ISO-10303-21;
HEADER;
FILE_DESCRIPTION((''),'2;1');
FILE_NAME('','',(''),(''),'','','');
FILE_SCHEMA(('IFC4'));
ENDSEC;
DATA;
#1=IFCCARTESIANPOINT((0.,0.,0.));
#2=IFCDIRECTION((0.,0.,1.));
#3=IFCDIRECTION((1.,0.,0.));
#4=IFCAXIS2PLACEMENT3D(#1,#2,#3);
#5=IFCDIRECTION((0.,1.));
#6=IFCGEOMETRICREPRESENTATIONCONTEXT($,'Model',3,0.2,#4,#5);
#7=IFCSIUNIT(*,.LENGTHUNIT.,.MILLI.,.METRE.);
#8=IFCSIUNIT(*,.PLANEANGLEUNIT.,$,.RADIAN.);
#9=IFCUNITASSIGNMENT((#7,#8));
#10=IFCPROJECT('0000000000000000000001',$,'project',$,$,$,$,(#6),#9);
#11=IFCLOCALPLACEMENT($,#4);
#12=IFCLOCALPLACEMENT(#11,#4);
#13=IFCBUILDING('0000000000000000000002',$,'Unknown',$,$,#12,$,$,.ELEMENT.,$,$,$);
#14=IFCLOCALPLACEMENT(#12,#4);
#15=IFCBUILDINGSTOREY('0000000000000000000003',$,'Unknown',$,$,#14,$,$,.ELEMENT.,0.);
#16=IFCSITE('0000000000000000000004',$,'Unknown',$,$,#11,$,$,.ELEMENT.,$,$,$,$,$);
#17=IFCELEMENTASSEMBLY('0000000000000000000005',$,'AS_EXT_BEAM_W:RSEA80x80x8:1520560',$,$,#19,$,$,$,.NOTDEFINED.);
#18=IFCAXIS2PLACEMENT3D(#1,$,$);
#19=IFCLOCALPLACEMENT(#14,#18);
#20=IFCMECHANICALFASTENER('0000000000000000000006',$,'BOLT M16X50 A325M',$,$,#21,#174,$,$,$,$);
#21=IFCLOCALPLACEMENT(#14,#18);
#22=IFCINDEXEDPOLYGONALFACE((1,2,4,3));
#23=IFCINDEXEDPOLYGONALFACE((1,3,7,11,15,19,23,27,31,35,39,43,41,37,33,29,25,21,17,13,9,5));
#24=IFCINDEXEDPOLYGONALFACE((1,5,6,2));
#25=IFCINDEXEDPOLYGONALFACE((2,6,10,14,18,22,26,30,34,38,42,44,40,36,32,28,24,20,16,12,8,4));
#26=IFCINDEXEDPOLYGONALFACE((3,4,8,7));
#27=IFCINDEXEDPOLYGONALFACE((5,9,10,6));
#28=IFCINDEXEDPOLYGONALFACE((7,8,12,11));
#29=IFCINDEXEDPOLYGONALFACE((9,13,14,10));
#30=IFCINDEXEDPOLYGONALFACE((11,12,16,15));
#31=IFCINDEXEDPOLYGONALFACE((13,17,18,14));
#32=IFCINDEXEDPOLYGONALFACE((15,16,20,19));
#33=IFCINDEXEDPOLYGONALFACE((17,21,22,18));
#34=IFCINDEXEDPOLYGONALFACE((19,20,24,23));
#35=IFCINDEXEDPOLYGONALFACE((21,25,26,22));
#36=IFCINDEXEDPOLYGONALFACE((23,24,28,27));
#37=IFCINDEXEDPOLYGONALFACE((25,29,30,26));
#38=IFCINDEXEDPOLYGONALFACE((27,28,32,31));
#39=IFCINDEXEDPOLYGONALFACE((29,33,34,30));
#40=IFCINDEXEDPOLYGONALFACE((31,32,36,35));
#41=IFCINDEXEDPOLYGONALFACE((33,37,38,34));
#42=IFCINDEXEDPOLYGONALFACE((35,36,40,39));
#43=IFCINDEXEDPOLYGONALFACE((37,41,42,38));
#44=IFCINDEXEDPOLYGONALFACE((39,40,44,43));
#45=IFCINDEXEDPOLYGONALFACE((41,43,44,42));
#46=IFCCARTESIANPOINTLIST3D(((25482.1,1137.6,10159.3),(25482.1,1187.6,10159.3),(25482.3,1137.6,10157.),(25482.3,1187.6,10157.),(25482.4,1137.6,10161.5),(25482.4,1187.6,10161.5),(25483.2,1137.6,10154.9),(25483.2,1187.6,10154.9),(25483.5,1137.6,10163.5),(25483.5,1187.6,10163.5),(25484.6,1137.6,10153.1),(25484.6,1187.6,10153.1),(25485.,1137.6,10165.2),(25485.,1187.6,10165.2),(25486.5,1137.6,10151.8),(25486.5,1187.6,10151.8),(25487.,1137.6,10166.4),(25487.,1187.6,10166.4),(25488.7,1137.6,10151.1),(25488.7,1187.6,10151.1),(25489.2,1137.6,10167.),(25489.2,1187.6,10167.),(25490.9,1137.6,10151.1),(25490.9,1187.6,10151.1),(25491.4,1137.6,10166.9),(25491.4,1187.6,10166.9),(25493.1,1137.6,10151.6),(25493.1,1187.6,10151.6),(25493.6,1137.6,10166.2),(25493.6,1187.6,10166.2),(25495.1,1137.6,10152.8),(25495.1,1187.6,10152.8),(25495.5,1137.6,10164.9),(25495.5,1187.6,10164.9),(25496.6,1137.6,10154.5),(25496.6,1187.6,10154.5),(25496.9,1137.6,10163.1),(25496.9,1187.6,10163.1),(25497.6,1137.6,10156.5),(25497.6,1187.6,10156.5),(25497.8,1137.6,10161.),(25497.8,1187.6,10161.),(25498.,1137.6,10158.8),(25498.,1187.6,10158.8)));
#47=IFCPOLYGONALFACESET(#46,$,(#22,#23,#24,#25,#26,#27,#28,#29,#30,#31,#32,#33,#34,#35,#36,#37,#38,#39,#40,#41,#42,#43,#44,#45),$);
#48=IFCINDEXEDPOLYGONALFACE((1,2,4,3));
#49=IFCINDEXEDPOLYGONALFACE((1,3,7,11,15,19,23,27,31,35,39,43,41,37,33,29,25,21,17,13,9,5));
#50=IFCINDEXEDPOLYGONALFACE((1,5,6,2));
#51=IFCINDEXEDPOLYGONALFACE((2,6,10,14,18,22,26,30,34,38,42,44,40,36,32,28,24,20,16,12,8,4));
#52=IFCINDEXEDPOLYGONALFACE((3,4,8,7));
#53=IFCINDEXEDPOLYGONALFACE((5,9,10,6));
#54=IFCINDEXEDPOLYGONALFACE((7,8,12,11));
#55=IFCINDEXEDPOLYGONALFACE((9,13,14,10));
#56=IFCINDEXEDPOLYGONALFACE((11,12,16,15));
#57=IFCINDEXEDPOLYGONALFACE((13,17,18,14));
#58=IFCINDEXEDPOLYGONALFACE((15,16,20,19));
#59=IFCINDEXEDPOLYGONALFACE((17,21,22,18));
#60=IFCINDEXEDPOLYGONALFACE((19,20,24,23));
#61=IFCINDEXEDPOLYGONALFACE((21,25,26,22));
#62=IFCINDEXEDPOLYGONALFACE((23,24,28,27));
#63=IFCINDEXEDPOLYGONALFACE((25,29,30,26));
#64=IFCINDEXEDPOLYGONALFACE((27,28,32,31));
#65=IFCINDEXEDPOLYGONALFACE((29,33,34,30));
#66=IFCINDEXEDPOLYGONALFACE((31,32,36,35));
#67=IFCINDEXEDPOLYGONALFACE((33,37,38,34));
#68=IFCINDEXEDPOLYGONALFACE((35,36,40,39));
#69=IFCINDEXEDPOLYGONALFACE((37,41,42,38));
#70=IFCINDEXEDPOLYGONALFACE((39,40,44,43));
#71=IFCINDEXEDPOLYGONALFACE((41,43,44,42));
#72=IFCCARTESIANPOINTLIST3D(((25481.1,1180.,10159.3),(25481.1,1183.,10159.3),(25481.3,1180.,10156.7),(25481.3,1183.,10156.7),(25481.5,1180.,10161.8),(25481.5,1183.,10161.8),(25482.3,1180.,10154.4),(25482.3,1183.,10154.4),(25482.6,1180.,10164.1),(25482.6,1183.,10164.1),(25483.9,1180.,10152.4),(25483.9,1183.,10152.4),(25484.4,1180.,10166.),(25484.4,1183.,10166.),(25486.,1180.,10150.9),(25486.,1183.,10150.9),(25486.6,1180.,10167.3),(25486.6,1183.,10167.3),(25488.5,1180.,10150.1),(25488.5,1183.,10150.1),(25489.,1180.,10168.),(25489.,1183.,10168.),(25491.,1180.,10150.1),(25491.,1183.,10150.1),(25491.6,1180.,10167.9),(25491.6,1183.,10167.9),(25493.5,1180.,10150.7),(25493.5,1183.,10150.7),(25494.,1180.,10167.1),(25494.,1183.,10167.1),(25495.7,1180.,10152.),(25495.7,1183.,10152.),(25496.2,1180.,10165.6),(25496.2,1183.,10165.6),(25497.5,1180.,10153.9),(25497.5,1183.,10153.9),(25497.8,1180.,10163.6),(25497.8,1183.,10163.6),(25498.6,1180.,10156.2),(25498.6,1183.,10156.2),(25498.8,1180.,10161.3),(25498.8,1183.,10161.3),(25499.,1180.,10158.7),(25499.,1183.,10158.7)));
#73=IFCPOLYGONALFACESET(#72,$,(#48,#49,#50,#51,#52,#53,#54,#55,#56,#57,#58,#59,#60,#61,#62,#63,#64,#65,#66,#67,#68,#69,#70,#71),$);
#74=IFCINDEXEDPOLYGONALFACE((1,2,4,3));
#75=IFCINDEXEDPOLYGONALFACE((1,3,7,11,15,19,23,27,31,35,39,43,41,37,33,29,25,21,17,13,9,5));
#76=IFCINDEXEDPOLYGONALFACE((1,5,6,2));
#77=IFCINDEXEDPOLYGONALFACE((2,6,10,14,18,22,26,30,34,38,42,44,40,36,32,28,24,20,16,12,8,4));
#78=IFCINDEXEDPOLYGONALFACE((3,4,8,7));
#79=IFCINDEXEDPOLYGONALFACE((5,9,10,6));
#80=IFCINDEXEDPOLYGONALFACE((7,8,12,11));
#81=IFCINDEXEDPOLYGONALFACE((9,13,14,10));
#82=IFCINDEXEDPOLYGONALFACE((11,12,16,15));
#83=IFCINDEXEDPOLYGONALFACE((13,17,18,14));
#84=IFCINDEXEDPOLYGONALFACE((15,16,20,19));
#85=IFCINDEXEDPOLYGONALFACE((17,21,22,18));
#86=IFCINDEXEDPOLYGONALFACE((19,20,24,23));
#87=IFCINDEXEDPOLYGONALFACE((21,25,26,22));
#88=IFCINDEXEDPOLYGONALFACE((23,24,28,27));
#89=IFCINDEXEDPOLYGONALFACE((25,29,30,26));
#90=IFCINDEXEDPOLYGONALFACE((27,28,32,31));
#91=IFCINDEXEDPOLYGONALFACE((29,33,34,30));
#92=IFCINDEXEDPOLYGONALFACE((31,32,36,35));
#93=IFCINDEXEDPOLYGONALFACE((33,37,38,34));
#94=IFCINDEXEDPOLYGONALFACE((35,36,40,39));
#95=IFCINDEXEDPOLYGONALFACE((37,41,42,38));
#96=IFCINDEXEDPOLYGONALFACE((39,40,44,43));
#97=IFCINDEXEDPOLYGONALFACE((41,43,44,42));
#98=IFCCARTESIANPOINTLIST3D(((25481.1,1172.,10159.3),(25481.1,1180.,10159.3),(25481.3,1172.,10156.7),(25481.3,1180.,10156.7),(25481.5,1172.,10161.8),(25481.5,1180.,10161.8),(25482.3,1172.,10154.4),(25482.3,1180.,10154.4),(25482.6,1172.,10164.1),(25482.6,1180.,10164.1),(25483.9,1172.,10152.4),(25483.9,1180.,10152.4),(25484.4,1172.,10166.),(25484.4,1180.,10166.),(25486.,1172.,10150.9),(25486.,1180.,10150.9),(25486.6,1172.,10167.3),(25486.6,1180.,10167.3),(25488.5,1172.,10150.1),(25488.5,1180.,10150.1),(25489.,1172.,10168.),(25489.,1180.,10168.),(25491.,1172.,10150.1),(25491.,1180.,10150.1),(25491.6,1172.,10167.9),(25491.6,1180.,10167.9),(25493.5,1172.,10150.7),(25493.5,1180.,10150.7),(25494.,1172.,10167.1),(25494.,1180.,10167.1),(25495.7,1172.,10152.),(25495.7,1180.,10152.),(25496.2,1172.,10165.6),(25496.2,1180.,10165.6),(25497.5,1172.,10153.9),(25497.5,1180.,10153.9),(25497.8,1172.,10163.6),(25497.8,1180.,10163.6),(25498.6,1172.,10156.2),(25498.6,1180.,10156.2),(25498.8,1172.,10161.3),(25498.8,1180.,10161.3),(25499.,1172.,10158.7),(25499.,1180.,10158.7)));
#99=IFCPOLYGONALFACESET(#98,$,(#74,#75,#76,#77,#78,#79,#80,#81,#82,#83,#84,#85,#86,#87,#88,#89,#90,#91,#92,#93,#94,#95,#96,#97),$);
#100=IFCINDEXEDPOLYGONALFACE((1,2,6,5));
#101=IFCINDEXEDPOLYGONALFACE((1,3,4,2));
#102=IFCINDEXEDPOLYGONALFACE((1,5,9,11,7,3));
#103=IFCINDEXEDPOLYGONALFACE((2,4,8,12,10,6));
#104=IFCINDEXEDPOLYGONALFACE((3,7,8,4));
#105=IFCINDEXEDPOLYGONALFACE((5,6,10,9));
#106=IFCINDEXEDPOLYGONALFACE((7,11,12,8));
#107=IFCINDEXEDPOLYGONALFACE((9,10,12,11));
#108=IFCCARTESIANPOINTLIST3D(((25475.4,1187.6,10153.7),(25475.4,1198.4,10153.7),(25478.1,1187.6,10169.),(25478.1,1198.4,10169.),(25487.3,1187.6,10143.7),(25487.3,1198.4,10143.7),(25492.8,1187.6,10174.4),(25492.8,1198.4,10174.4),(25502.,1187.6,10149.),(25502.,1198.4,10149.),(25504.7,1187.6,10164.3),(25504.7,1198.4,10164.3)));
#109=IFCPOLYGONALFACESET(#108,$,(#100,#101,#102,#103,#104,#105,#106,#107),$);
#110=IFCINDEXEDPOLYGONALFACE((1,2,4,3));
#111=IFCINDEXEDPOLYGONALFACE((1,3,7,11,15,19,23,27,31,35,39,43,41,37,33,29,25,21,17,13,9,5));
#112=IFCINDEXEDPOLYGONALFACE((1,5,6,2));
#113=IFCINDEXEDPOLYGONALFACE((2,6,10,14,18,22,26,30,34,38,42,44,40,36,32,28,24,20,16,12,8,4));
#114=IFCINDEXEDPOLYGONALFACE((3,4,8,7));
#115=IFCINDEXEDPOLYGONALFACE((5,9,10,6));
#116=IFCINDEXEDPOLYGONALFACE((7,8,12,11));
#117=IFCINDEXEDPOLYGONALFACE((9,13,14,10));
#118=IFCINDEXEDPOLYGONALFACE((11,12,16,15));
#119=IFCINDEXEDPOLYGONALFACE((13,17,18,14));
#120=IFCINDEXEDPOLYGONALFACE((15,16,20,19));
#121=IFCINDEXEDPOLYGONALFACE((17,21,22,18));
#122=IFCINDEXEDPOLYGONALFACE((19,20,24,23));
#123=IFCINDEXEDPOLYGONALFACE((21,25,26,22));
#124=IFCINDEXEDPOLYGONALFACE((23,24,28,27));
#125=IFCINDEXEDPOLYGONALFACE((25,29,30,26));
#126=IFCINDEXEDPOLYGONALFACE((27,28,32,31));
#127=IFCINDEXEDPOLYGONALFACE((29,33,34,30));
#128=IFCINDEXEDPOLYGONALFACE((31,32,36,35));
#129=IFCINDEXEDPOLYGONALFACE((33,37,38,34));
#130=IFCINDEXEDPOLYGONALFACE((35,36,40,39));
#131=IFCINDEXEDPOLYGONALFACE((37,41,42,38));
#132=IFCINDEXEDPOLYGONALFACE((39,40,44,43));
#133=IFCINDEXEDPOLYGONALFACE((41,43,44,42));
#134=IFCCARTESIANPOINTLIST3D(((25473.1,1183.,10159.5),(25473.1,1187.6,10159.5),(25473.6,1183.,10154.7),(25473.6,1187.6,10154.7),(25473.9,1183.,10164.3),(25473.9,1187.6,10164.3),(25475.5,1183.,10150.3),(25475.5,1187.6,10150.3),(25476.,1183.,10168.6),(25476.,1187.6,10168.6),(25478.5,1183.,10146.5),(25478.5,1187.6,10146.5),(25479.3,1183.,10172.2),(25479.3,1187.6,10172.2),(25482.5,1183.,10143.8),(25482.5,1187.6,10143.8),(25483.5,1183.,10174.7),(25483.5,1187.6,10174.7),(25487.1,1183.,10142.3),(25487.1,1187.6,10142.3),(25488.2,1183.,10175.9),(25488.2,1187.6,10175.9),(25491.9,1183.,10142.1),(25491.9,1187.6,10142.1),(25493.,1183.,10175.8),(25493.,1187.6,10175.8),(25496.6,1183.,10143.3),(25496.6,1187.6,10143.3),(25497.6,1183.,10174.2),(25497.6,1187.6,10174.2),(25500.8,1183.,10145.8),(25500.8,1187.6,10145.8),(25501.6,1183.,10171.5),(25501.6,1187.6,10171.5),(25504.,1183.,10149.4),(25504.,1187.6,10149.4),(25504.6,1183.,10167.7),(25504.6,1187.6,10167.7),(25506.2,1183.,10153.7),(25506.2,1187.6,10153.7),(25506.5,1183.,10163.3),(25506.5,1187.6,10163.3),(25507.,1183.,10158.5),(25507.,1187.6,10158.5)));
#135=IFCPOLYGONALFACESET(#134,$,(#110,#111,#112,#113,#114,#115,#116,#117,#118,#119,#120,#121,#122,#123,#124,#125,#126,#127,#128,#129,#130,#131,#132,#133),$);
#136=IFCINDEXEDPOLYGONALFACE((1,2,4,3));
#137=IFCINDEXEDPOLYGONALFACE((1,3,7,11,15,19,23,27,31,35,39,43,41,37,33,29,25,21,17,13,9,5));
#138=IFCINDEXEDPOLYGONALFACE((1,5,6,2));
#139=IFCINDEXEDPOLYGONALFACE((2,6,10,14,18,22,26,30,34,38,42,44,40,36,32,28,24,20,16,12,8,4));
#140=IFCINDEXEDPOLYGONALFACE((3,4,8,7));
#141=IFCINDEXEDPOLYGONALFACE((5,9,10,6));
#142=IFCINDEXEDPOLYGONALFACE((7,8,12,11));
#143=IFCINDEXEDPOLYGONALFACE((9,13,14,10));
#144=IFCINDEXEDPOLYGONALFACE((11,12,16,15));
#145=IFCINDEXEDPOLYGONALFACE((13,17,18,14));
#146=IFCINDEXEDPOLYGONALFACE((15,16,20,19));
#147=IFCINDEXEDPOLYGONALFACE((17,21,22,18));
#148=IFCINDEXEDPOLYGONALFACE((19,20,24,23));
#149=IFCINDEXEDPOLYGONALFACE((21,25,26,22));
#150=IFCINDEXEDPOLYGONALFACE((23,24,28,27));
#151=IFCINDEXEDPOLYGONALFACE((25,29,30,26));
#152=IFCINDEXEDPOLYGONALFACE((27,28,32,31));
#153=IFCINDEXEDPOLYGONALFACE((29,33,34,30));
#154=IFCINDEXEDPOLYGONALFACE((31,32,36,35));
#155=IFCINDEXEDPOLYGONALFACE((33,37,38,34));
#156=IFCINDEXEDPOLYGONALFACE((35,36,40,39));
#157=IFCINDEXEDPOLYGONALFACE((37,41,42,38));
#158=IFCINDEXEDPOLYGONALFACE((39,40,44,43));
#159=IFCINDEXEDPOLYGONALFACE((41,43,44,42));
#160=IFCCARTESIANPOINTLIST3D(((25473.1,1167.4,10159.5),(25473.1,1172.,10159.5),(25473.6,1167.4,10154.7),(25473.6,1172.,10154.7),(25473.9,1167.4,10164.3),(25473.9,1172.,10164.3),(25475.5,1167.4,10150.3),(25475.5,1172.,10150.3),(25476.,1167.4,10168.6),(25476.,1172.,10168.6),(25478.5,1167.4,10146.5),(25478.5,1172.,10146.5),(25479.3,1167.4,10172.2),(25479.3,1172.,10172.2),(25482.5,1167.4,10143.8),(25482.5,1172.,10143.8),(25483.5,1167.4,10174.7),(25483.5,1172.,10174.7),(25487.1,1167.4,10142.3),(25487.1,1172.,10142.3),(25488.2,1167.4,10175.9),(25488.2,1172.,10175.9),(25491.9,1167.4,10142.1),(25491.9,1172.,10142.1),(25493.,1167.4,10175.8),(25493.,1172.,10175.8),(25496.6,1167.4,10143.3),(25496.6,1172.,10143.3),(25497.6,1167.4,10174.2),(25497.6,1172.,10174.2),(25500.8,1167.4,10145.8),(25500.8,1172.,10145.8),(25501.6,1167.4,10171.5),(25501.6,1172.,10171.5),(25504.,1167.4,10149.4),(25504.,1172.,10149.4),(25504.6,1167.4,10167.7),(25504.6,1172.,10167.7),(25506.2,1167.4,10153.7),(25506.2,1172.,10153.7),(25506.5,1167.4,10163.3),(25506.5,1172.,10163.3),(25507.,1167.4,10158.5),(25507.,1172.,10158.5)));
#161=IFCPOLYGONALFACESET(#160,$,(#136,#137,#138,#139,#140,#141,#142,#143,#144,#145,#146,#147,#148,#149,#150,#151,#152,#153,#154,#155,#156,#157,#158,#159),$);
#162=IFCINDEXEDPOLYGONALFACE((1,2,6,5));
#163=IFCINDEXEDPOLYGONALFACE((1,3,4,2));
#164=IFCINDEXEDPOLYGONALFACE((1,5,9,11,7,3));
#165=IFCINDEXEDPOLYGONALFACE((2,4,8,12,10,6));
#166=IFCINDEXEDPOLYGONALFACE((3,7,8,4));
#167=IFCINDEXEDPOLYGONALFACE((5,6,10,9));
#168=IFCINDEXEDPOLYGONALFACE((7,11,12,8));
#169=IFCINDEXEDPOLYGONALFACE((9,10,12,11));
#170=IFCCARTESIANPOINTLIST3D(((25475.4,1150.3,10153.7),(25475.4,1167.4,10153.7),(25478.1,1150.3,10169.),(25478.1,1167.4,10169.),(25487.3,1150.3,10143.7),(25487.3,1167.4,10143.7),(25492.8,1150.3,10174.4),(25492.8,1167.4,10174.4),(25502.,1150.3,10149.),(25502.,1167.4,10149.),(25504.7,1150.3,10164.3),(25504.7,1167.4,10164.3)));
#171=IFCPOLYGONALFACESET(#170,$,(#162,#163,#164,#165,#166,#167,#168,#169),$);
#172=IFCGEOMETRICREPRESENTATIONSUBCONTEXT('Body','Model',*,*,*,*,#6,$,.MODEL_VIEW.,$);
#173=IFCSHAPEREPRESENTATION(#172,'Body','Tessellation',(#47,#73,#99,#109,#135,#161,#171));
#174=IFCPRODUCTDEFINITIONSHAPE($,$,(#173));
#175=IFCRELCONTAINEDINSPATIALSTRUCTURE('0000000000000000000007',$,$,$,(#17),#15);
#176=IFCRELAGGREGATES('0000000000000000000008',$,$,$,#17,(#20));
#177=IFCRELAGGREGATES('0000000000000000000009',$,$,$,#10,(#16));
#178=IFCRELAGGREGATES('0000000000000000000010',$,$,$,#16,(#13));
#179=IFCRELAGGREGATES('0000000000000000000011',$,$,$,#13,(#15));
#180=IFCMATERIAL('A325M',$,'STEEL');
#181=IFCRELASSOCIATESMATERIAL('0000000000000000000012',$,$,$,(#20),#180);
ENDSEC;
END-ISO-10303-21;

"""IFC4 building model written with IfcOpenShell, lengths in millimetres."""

from ifc_helpers import new_model, si_unit, direction, frame, origin_with_axes, place, context, subcontext, project, spatial, line, arc, indexed_curve, outline, extrude, source, transform, mapped, material, element, aggregate, save


model = new_model("IFC4")

# Units and contexts
model_context = context("Model", 3, precision=0.2, world=origin_with_axes(), true_north=direction((0.0, 1.0)))
body_context = subcontext(model_context, "Body", "Model", "MODEL_VIEW")
ifc_project = project(units=[si_unit("LENGTHUNIT", "METRE", prefix="MILLI"), si_unit("PLANEANGLEUNIT", "RADIAN")], contexts=[model_context])

# Site, building, storey
site_placement = place(None, origin_with_axes())
site = spatial("IfcSite", under=ifc_project, at=site_placement, Name="Unknown", CompositionType="ELEMENT")
building_placement = place(site_placement, origin_with_axes())
building = spatial("IfcBuilding", under=site, at=building_placement, Name="Unknown", CompositionType="ELEMENT")
storey_placement = place(building_placement, origin_with_axes())
storey = spatial("IfcBuildingStorey", under=building, at=storey_placement, Name="Unknown", CompositionType="ELEMENT", Elevation=0.0)

# Element assembly
assembly_1_placement = place(storey_placement, frame((25427.6, 1140.0, 10164.9), z_axis=(0.0, -1.0, 0.0), x_axis=(0.984808, 0.0, -0.173648)))
assembly_1 = element("IfcElementAssembly", 1, at=assembly_1_placement, inside=storey, Name="AS_EXT_BEAM_W:RSEA80x80x8:1520560", PredefinedType="NOTDEFINED")

# Mechanical fastener
ifc_material_1 = material(Name="A325M", Category="STEEL")
shared_shape_1 = source(origin_with_axes(), body_context, "Body", "SweptSolid", [
    extrude(outline(indexed_curve([(8.0, 0.0), (0.0, 8.0), (-8.0, 0.0), (0.0, -8.0)], segments=[arc(1, 2, 3), arc(3, 4, 1)])), frame((0.0, 0.0, 15.6), z_axis=(0.0, 0.0, -1.0), x_axis=(0.0, 1.0, 0.0)), (0.0, 0.0, 1.0), 50.0),
    extrude(outline(indexed_curve([(9.0, 0.0), (0.0, 9.0), (-9.0, 0.0), (0.0, -9.0)], segments=[arc(1, 2, 3), arc(3, 4, 1)])), frame((0.0, 0.0, 11.0), z_axis=(0.0, 0.0, -1.0), x_axis=(0.0, 1.0, 0.0)), (0.0, 0.0, 1.0), 3.0),
    extrude(outline(indexed_curve([(9.0, 0.0), (0.0, 9.0), (-9.0, 0.0), (0.0, -9.0)], segments=[arc(1, 2, 3), arc(3, 4, 1)])), frame((0.0, 0.0, 8.0), z_axis=(0.0, 0.0, -1.0), x_axis=(0.0, 1.0, 0.0)), (0.0, 0.0, 1.0), 8.0),
    extrude(outline(indexed_curve([(15.6, 0.0), (7.8, 13.5), (-7.8, 13.5), (-15.6, 0.0), (-7.8, -13.5), (7.8, -13.5)], segments=[line(1, 2, 3, 4, 5, 6, 1)])), frame((0.0, 0.0, 26.4), z_axis=(0.0, 0.0, -1.0), x_axis=(0.0, 1.0, 0.0)), (0.0, 0.0, 1.0), 10.8),
    extrude(outline(indexed_curve([(17.0, 0.0), (0.0, 17.0), (-17.0, 0.0), (0.0, -17.0)], segments=[arc(1, 2, 3), arc(3, 4, 1)])), frame((0.0, 0.0, 15.6), z_axis=(0.0, 0.0, -1.0), x_axis=(0.0, 1.0, 0.0)), (0.0, 0.0, 1.0), 4.6),
    extrude(outline(indexed_curve([(17.0, 0.0), (0.0, 17.0), (-17.0, 0.0), (0.0, -17.0)], segments=[arc(1, 2, 3), arc(3, 4, 1)])), frame((0.0, 0.0, 0.0), z_axis=(0.0, 0.0, -1.0), x_axis=(0.0, 1.0, 0.0)), (0.0, 0.0, 1.0), 4.6),
    extrude(outline(indexed_curve([(15.6, 0.0), (7.8, 13.5), (-7.8, 13.5), (-15.6, 0.0), (-7.8, -13.5), (7.8, -13.5)], segments=[line(1, 2, 3, 4, 5, 6, 1)])), frame((0.0, 0.0, -4.6), z_axis=(0.0, 0.0, -1.0), x_axis=(0.0, 1.0, 0.0)), (0.0, 0.0, 1.0), 17.1),
])
mechanical_fastener_1_placement = place(assembly_1_placement, frame((62.5, 5.0, -32.0), z_axis=(0.0, 0.0, -1.0), x_axis=(1.0, 0.0, 0.0)))
mechanical_fastener_1 = element("IfcMechanicalFastener", 2, at=mechanical_fastener_1_placement, material=ifc_material_1, Name="BOLT M16X50 A325M", context=body_context, shape_type="MappedRepresentation", body=[
    mapped(shared_shape_1, transform((0.0, 0.0, 0.0))),
])
aggregate(assembly_1, [mechanical_fastener_1])

save(model, "model.ifc")
